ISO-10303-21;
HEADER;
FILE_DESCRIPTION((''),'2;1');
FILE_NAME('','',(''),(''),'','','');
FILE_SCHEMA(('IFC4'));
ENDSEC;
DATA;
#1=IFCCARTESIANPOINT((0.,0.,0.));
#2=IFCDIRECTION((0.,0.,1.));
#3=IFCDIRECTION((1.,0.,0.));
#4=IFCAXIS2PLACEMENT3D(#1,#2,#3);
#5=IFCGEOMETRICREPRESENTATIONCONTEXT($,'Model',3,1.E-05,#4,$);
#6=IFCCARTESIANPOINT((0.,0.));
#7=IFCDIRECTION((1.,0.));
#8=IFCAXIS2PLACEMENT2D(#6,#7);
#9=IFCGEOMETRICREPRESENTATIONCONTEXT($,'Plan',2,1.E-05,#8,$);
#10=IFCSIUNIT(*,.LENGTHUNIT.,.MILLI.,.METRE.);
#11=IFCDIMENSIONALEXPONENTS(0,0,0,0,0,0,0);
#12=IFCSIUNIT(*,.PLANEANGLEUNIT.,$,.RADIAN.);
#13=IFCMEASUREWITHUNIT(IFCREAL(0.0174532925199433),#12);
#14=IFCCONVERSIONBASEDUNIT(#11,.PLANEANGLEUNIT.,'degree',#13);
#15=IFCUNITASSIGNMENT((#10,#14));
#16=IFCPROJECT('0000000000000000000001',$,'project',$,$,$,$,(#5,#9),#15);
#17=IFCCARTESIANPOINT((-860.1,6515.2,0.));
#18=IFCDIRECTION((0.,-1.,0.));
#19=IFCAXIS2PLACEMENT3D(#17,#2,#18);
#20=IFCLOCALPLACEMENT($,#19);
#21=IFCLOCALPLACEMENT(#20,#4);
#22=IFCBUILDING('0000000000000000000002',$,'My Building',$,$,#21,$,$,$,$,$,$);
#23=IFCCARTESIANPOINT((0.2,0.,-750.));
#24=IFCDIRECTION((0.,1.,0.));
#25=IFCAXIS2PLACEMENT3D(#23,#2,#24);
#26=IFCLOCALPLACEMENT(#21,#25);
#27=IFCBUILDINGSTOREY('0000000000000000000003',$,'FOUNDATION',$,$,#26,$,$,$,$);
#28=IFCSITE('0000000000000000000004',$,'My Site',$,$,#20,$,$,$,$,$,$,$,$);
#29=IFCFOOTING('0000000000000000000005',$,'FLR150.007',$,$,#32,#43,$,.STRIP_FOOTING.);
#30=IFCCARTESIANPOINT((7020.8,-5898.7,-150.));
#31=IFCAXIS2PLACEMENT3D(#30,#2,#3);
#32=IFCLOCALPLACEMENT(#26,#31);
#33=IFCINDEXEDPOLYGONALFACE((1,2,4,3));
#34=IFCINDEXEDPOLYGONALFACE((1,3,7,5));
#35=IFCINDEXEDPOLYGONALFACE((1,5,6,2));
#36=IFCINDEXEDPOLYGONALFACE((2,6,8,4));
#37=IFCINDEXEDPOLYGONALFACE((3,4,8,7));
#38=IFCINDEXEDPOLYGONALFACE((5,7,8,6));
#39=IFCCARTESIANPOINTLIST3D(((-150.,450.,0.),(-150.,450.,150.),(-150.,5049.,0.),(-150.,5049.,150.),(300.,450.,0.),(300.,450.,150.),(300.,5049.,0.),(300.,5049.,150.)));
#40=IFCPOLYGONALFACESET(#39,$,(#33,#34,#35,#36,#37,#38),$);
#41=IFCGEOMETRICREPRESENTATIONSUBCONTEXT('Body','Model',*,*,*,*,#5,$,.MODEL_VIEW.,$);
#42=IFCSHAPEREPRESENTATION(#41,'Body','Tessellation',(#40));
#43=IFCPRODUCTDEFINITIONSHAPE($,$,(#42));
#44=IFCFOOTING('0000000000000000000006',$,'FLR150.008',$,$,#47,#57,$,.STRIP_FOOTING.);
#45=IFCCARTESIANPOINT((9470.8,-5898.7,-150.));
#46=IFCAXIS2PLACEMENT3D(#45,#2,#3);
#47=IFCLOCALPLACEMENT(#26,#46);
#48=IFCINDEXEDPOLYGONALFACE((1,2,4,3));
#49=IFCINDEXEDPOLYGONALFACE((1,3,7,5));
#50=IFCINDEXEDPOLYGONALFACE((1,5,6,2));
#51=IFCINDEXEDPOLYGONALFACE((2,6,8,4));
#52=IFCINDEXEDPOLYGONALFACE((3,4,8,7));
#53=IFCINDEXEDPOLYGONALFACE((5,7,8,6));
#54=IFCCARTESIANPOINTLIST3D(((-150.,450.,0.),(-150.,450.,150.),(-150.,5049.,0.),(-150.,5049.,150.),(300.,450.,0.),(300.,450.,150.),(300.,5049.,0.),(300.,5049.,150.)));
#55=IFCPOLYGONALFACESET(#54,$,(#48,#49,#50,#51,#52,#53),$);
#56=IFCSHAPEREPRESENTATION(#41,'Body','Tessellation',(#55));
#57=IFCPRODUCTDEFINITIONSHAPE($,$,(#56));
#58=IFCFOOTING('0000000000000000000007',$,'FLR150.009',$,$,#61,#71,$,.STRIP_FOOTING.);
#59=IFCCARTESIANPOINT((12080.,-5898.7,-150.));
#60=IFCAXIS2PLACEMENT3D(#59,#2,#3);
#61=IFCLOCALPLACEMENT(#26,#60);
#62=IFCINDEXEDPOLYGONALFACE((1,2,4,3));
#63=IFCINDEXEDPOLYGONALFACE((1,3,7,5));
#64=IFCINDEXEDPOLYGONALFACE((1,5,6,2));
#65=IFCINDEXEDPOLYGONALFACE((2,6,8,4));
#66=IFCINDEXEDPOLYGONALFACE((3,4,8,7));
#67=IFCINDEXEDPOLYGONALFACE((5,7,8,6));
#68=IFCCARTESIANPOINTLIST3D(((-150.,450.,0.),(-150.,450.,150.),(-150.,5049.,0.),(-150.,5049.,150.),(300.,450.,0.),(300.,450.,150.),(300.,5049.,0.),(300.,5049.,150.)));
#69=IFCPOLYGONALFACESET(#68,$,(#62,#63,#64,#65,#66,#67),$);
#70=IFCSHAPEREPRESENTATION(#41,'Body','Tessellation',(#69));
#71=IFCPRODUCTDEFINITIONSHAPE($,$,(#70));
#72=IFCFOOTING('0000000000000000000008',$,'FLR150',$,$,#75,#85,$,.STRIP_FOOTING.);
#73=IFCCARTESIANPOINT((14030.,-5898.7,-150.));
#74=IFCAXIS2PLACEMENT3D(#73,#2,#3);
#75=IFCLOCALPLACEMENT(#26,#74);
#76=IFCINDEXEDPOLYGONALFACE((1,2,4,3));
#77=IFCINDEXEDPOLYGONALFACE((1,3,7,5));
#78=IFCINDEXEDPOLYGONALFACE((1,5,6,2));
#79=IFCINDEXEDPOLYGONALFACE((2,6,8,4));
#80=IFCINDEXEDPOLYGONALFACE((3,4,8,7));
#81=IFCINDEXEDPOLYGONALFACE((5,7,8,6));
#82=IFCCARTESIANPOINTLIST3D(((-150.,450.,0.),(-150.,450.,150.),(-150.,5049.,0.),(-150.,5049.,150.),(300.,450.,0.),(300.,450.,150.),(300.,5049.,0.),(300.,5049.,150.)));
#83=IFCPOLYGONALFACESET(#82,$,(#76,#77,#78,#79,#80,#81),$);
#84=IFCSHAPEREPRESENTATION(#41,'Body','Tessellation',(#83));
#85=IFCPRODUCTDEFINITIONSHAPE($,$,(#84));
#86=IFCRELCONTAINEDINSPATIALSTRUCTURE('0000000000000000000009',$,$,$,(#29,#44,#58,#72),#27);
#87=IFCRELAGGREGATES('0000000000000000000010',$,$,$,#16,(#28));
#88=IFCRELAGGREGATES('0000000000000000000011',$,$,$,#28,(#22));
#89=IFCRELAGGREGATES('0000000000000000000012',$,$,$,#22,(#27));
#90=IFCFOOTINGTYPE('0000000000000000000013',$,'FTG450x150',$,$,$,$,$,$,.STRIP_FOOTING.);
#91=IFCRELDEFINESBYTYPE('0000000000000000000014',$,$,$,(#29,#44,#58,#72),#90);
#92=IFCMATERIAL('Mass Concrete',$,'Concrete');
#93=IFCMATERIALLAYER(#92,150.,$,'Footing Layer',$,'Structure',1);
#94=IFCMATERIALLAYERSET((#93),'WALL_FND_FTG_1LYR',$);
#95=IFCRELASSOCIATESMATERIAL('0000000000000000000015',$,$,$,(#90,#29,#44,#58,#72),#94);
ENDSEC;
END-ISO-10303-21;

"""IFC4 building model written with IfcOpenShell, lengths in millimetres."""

from ifc_helpers import new_model, entity, si_unit, converted_unit, frame, origin_with_axes, origin_2d_with_axis, place, context, subcontext, project, spatial, line, indexed_curve, outline, extrude, material, layer, layer_set, layer_usage, type_object, element, save


model = new_model("IFC4")

# Units and contexts
model_context = context("Model", 3, precision=1e-05, world=origin_with_axes())
plan_context = context("Plan", 2, precision=1e-05, world=origin_2d_with_axis())
body_context = subcontext(model_context, "Body", "Model", "MODEL_VIEW")
ifc_project = project(units=[si_unit("LENGTHUNIT", "METRE", prefix="MILLI"), converted_unit("PLANEANGLEUNIT", "degree", entity("IfcReal", 0.0174532925199433), si_unit("PLANEANGLEUNIT", "RADIAN"), dimensions=[0, 0, 0, 0, 0, 0, 0])], contexts=[model_context, plan_context])

# Site, building, storey
site_placement = place(None, frame((-860.1, 6515.2, 0.0), z_axis=(0.0, 0.0, 1.0), x_axis=(0.0, -1.0, 0.0)))
site = spatial("IfcSite", under=ifc_project, at=site_placement, Name="My Site")
building_placement = place(site_placement, frame((0.0, 0.0, 0.0), z_axis=(0.0, 0.0, 1.0), x_axis=(1.0, 0.0, 0.0)))
building = spatial("IfcBuilding", under=site, at=building_placement, Name="My Building")
storey_placement = place(building_placement, frame((0.2, 0.0, -750.0), z_axis=(0.0, 0.0, 1.0), x_axis=(0.0, 1.0, 0.0)))
storey = spatial("IfcBuildingStorey", under=building, at=storey_placement, Name="FOUNDATION")

# Footings
ifc_material_1 = material(Name="Mass Concrete", Category="Concrete")
ifc_layer_1 = layer(ifc_material_1, 150.0, Name="Footing Layer", Category="Structure", Priority=1)
ifc_layer_set_1 = layer_set([ifc_layer_1], Name="WALL_FND_FTG_1LYR")
ifc_layer_usage_1 = layer_usage(ifc_layer_set_1, "AXIS3", "POSITIVE", 0.0)
footing_type = type_object("IfcFootingType", Name="FTG450x150", PredefinedType="STRIP_FOOTING", material=ifc_layer_set_1)
footing_1_placement = place(storey_placement, frame((7020.8, -5898.7, -150.0), z_axis=(0.0, 0.0, 1.0), x_axis=(1.0, 0.0, 0.0)))
element("IfcFooting", 1, at=footing_1_placement, inside=storey, type_object=footing_type, material=ifc_layer_usage_1, Name="FLR150.007", PredefinedType="STRIP_FOOTING", context=body_context, shape_type="SweptSolid", body=[
    extrude(outline(indexed_curve([(-150.0, 450.0), (300.0, 450.0), (300.0, 5049.0), (-150.0, 5049.0)], segments=[line(3, 2), line(2, 1), line(1, 4), line(4, 3)], self_intersect=False)), None, (0.0, 0.0, 1.0), 150.0),
])
ifc_layer_usage_2 = layer_usage(ifc_layer_set_1, "AXIS3", "POSITIVE", 0.0)
footing_2_placement = place(storey_placement, frame((9470.8, -5898.7, -150.0), z_axis=(0.0, 0.0, 1.0), x_axis=(1.0, 0.0, 0.0)))
element("IfcFooting", 2, at=footing_2_placement, inside=storey, type_object=footing_type, material=ifc_layer_usage_2, Name="FLR150.008", PredefinedType="STRIP_FOOTING", context=body_context, shape_type="SweptSolid", body=[
    extrude(outline(indexed_curve([(-150.0, 450.0), (300.0, 450.0), (300.0, 5049.0), (-150.0, 5049.0)], segments=[line(3, 2), line(2, 1), line(1, 4), line(4, 3)], self_intersect=False)), None, (0.0, 0.0, 1.0), 150.0),
])
ifc_layer_usage_3 = layer_usage(ifc_layer_set_1, "AXIS3", "POSITIVE", 0.0)
footing_3_placement = place(storey_placement, frame((12080.0, -5898.7, -150.0), z_axis=(0.0, 0.0, 1.0), x_axis=(1.0, 0.0, 0.0)))
element("IfcFooting", 3, at=footing_3_placement, inside=storey, type_object=footing_type, material=ifc_layer_usage_3, Name="FLR150.009", PredefinedType="STRIP_FOOTING", context=body_context, shape_type="SweptSolid", body=[
    extrude(outline(indexed_curve([(-150.0, 450.0), (300.0, 450.0), (300.0, 5049.0), (-150.0, 5049.0)], segments=[line(3, 2), line(2, 1), line(1, 4), line(4, 3)], self_intersect=False)), None, (0.0, 0.0, 1.0), 150.0),
])
ifc_layer_usage_4 = layer_usage(ifc_layer_set_1, "AXIS3", "POSITIVE", 0.0)
footing_4_placement = place(storey_placement, frame((14030.0, -5898.7, -150.0), z_axis=(0.0, 0.0, 1.0), x_axis=(1.0, 0.0, 0.0)))
element("IfcFooting", 4, at=footing_4_placement, inside=storey, type_object=footing_type, material=ifc_layer_usage_4, Name="FLR150", PredefinedType="STRIP_FOOTING", context=body_context, shape_type="SweptSolid", body=[
    extrude(outline(indexed_curve([(-150.0, 450.0), (300.0, 450.0), (300.0, 5049.0), (-150.0, 5049.0)], segments=[line(3, 2), line(2, 1), line(1, 4), line(4, 3)], self_intersect=False)), None, (0.0, 0.0, 1.0), 150.0),
])

save(model, "model.ifc")
